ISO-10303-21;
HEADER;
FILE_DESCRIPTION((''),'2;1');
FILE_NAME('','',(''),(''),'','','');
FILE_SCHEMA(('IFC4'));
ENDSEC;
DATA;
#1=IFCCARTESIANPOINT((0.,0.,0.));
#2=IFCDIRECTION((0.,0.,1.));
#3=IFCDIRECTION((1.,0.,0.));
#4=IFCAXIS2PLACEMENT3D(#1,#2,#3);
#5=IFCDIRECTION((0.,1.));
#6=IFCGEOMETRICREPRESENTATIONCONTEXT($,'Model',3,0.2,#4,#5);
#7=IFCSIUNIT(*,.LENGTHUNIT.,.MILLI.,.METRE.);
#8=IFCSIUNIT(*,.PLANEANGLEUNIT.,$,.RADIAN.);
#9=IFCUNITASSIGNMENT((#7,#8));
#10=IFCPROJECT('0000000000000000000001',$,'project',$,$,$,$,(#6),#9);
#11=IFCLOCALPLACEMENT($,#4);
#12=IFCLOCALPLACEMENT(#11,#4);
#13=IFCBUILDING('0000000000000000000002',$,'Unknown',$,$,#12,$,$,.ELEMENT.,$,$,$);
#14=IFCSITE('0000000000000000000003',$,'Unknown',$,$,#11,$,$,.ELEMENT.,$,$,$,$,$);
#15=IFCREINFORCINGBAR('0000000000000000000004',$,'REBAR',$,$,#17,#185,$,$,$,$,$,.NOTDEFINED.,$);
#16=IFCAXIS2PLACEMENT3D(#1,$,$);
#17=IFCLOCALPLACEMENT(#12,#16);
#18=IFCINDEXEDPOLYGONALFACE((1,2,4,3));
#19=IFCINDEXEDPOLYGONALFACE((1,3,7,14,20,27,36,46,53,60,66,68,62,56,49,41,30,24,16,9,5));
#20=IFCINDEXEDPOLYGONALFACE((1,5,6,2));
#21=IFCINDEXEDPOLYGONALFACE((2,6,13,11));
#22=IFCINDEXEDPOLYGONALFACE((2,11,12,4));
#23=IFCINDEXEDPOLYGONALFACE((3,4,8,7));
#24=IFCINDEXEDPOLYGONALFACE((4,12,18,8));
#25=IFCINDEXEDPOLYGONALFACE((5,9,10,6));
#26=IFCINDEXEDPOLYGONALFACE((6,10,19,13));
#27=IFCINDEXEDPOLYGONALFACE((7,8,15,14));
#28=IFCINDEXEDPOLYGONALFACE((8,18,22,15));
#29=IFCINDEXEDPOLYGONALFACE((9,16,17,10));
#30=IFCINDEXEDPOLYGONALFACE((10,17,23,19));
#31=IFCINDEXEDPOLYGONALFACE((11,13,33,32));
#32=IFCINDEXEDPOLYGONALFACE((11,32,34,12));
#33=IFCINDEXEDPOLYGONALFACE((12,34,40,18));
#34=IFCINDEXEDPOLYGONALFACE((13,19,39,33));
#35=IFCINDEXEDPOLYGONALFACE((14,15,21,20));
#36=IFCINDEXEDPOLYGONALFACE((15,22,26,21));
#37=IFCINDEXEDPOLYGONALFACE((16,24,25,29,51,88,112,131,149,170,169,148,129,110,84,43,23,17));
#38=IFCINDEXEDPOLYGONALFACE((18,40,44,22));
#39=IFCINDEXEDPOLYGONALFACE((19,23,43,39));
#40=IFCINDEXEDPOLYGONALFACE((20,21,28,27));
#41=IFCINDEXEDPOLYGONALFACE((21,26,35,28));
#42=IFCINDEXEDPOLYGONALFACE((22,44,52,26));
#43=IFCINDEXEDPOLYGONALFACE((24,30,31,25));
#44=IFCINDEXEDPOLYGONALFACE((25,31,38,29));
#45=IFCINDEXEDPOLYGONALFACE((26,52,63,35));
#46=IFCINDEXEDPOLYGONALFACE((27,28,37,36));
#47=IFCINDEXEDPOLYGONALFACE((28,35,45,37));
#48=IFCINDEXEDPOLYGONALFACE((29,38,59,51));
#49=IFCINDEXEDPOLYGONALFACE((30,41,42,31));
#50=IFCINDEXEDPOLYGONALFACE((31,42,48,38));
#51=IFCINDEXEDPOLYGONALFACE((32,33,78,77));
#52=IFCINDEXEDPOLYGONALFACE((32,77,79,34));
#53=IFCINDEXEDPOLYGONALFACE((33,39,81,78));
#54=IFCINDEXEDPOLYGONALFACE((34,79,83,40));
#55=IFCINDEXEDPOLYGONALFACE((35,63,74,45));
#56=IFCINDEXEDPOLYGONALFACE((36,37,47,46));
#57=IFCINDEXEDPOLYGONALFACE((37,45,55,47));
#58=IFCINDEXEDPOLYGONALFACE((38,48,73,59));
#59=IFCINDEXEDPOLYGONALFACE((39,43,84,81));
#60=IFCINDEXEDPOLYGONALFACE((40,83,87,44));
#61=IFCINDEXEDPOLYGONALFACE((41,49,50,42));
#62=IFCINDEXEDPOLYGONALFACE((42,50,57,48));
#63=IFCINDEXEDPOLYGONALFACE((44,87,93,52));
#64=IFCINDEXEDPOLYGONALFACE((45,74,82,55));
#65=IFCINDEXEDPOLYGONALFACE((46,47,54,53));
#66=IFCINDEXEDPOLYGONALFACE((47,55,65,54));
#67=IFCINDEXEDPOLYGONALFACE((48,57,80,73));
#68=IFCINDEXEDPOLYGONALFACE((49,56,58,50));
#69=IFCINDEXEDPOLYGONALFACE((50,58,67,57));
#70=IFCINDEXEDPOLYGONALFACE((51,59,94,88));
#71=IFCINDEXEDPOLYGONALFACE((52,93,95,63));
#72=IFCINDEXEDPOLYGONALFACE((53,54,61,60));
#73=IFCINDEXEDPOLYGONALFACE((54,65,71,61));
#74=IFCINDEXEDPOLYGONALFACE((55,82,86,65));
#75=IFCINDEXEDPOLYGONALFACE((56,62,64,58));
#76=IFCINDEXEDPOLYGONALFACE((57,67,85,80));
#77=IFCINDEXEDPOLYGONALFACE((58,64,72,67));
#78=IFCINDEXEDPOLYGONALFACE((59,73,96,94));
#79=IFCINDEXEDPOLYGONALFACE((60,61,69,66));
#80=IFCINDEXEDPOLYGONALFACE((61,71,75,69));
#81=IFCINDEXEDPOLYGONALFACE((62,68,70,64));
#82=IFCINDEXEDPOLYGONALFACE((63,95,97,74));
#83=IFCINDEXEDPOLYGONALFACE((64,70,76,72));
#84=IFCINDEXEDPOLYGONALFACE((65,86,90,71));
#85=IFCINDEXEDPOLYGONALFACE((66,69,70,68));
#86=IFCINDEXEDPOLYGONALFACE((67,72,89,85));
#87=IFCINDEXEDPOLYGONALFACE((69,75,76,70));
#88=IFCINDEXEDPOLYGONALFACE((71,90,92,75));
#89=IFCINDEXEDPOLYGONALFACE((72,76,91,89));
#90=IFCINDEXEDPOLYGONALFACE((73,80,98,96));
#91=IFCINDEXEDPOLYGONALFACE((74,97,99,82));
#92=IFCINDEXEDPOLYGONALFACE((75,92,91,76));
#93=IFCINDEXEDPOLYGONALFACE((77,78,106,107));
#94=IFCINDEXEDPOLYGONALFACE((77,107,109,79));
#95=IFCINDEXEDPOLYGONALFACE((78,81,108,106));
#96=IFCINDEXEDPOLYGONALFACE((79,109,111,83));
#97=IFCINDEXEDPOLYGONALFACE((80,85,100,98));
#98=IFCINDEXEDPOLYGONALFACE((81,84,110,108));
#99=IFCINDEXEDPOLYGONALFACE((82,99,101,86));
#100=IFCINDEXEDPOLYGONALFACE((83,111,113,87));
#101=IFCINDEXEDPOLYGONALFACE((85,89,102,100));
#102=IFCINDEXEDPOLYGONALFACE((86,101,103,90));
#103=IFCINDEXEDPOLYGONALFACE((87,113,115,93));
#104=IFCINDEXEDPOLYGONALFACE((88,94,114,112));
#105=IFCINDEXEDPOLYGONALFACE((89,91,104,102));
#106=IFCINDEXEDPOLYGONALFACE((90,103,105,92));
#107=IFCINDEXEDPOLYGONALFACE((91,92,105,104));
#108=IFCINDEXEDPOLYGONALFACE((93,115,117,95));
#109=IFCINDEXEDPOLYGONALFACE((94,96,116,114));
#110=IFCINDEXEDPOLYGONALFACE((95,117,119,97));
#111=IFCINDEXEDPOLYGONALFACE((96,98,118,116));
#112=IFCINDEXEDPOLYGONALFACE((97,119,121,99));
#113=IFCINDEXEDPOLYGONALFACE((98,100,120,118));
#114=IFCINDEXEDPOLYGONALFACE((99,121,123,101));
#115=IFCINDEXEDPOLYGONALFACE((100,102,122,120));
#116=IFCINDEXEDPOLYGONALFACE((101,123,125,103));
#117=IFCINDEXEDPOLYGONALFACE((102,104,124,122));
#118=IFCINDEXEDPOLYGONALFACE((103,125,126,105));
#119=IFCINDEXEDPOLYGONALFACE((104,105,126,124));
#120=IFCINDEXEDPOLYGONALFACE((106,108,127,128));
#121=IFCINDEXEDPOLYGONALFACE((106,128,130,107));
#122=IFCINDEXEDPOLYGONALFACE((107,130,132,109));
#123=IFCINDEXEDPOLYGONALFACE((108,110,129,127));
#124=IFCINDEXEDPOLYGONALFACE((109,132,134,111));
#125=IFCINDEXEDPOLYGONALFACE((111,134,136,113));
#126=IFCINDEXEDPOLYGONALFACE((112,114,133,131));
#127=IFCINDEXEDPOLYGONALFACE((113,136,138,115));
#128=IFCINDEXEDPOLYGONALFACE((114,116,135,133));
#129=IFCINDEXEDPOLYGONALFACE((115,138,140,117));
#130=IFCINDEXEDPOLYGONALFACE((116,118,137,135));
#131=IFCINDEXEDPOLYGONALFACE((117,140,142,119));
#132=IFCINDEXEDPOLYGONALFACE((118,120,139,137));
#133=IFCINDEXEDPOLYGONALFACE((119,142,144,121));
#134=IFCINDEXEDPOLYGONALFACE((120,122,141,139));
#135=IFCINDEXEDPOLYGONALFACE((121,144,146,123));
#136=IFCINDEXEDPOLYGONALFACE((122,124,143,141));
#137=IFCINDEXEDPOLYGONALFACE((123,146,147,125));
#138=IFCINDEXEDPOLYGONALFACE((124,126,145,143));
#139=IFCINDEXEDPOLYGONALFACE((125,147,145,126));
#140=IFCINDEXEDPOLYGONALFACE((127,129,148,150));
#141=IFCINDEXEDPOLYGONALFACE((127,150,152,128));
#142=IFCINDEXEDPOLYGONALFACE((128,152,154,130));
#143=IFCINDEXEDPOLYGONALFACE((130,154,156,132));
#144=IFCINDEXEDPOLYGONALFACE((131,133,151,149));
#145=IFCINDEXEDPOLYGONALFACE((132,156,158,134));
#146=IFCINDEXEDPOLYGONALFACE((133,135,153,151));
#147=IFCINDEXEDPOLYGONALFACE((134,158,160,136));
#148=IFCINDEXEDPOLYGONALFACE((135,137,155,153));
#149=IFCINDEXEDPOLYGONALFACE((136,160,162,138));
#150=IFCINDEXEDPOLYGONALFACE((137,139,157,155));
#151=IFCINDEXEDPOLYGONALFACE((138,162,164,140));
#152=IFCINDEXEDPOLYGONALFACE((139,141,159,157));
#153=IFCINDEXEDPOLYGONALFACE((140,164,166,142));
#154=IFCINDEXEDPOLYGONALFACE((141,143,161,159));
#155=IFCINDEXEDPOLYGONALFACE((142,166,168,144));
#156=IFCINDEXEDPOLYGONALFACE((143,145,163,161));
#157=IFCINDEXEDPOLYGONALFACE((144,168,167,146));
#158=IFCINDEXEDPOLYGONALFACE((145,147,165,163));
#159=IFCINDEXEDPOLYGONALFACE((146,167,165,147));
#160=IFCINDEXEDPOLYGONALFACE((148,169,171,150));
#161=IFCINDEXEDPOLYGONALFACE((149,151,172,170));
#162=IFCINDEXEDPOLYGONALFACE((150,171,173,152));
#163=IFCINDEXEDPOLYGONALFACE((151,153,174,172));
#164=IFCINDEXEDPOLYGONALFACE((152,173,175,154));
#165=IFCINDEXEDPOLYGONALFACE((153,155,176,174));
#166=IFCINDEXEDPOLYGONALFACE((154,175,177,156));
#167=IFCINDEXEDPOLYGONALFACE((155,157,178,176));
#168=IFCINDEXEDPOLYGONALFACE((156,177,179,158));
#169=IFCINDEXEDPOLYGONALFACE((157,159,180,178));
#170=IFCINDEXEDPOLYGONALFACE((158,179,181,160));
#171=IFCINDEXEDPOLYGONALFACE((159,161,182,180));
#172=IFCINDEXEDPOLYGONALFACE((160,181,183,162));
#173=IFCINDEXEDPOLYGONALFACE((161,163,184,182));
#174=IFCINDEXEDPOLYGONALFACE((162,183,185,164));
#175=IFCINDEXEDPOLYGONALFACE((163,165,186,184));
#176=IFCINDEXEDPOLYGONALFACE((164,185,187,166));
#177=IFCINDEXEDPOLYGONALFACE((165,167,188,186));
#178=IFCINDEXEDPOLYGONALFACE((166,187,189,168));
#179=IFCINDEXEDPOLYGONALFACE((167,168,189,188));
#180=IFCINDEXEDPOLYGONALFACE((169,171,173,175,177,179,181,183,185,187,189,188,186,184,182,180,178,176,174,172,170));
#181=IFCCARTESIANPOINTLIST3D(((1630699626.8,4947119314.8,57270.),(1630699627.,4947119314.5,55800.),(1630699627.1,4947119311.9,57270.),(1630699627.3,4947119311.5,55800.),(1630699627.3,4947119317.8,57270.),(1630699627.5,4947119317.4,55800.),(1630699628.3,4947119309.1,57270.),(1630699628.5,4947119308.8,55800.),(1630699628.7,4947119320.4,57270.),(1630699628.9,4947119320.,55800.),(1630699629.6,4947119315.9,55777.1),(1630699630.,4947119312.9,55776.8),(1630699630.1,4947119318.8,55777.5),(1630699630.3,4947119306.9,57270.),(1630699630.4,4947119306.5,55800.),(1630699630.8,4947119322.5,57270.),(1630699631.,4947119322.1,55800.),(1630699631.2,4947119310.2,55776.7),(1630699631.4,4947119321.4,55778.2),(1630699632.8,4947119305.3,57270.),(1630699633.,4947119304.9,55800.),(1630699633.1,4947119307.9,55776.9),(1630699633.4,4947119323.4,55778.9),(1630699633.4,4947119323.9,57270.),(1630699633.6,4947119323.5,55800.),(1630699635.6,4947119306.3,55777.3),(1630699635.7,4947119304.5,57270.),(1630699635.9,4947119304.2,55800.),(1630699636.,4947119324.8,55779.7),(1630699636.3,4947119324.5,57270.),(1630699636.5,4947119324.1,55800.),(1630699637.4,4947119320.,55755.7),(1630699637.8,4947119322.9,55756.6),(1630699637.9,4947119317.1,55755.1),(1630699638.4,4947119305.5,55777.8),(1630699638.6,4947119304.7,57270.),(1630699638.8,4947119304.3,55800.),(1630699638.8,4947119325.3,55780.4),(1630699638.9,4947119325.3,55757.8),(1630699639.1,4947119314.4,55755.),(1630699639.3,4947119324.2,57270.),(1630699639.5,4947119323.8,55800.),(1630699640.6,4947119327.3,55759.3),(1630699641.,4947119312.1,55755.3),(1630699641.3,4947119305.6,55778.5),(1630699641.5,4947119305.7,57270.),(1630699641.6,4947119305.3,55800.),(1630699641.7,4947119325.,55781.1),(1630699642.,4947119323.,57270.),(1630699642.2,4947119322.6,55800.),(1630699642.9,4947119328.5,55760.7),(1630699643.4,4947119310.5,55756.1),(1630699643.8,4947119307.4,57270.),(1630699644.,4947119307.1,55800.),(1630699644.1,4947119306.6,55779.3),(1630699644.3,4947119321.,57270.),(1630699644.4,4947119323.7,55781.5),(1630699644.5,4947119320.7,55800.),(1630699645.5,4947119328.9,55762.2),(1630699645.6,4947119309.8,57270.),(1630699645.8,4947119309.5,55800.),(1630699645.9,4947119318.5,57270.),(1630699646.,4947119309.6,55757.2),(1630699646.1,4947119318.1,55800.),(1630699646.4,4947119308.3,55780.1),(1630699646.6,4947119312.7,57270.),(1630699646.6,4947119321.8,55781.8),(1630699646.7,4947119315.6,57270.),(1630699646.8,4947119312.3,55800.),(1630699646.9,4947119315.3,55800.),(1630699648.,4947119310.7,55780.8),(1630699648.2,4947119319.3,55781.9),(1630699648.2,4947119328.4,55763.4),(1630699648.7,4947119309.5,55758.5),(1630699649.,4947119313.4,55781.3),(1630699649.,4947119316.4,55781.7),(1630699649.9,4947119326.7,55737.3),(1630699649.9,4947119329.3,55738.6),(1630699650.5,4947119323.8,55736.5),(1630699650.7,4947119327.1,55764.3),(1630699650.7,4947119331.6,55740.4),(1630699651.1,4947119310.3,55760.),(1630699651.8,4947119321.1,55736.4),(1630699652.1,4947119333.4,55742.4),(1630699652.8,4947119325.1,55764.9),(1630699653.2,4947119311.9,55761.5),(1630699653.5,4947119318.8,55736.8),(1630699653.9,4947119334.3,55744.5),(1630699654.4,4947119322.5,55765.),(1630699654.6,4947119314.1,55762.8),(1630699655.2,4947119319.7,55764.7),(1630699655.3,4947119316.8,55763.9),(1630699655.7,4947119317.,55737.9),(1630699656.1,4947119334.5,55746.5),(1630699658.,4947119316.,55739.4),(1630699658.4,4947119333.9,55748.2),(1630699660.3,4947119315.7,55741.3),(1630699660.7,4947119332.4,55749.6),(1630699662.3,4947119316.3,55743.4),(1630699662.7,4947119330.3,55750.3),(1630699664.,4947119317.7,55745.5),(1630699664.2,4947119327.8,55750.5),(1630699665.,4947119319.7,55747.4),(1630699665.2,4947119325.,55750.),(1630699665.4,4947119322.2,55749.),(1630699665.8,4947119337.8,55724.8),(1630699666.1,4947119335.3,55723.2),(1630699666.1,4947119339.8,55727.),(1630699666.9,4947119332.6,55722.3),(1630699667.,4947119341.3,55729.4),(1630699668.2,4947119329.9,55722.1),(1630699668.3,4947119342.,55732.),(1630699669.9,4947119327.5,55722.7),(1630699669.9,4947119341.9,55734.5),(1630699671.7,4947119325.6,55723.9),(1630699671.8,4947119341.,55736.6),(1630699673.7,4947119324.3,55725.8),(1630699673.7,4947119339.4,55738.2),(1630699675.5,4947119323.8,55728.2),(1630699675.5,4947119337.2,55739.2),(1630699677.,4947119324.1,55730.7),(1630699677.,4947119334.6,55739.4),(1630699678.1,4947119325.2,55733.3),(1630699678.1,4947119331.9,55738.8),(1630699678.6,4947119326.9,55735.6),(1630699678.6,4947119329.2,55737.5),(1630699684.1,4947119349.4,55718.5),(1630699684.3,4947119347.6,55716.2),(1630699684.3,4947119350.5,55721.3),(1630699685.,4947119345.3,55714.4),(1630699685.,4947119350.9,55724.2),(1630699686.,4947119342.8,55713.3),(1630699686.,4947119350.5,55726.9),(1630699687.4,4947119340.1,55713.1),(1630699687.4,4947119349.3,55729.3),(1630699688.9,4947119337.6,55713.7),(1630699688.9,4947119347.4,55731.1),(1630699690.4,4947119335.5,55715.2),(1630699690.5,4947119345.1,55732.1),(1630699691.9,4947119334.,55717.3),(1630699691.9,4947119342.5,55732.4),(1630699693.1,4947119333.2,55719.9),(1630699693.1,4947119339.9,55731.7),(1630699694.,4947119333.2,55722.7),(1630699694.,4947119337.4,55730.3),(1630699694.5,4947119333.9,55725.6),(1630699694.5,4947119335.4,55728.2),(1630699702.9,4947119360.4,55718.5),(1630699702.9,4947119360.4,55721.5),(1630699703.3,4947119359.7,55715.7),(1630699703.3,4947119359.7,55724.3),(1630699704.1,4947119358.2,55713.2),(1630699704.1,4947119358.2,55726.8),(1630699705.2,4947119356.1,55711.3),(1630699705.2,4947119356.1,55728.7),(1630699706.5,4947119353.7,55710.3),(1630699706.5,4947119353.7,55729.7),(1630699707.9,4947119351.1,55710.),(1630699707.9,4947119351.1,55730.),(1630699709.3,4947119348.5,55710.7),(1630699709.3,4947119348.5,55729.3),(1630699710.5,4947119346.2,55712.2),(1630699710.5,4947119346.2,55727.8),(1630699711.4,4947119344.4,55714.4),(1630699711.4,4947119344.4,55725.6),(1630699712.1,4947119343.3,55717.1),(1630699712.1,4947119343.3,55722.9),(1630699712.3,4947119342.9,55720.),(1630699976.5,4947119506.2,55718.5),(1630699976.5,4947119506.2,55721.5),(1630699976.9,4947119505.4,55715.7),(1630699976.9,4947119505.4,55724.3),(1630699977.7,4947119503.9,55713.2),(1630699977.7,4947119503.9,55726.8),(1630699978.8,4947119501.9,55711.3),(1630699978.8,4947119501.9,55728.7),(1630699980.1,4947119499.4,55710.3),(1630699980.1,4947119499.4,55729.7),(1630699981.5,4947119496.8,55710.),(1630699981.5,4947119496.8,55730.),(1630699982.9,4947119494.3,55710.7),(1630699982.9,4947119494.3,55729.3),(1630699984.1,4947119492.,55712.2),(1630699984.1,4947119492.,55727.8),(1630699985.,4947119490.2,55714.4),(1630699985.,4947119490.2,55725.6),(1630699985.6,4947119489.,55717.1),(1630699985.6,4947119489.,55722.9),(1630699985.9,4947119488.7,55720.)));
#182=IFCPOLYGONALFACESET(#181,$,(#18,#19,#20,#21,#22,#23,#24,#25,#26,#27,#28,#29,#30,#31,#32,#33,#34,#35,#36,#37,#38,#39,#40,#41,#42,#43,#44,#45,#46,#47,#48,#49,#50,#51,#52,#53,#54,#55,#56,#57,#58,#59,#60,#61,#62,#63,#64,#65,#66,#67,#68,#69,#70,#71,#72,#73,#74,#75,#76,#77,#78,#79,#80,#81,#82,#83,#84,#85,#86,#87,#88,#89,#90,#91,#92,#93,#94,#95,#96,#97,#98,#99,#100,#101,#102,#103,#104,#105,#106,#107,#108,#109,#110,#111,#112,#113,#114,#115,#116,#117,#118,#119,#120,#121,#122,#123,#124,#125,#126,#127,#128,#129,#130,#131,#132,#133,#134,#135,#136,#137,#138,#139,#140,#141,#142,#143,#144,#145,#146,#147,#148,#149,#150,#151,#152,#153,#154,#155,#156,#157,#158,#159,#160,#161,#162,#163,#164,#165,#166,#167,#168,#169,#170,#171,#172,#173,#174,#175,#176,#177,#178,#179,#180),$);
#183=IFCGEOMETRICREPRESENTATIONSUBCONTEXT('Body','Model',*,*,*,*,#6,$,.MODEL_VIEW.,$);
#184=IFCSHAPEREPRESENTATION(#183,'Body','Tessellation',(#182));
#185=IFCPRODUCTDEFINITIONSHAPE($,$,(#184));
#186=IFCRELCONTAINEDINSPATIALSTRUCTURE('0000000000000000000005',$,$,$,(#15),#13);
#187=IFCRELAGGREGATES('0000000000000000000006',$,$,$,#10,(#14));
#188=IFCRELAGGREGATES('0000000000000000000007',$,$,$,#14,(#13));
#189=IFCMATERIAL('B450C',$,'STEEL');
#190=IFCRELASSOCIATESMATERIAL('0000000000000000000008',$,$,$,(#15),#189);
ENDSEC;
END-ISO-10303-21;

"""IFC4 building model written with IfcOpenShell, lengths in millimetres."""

from ifc_helpers import new_model, entity, si_unit, direction, frame, origin_with_axes, place, context, subcontext, project, spatial, material, element, save


model = new_model("IFC4")

# Units and contexts
model_context = context("Model", 3, precision=0.2, world=origin_with_axes(), true_north=direction((0.0, 1.0)))
body_context = subcontext(model_context, "Body", "Model", "MODEL_VIEW")
ifc_project = project(units=[si_unit("LENGTHUNIT", "METRE", prefix="MILLI"), si_unit("PLANEANGLEUNIT", "RADIAN")], contexts=[model_context])

# Site, building
site_placement = place(None, origin_with_axes())
site = spatial("IfcSite", under=ifc_project, at=site_placement, Name="Unknown", CompositionType="ELEMENT")
building_placement = place(site_placement, origin_with_axes())
building = spatial("IfcBuilding", under=site, at=building_placement, Name="Unknown", CompositionType="ELEMENT")

# Reinforcing bar
ifc_material = material(Name="B450C", Category="STEEL")
reinforcing_bar_1_placement = place(building_placement, frame((1630699569.3, 4947119334.7, 55670.0), z_axis=(0.470504, -0.882398, 0.0), x_axis=(0.0, 0.0, 1.0)))
element("IfcReinforcingBar", 1, at=reinforcing_bar_1_placement, inside=building, material=ifc_material, Name="REBAR", PredefinedType="NOTDEFINED", context=body_context, shape_type="AdvancedSweptSolid", body=[
    entity("IfcSweptDiskSolid", entity("IfcIndexedPolyCurve", entity("IfcCartesianPointList3D", [[50.0, -440.0, 50.1], [50.0, -130.0, 50.0], [73.4, -73.4, 50.0], [130.0, -50.0, 50.0], [1600.0, -50.0, 49.6]]), [entity("IfcLineIndex", [1, 2]), entity("IfcArcIndex", [2, 3, 4]), entity("IfcLineIndex", [4, 5])]), 10.0),
])

save(model, "model.ifc")
